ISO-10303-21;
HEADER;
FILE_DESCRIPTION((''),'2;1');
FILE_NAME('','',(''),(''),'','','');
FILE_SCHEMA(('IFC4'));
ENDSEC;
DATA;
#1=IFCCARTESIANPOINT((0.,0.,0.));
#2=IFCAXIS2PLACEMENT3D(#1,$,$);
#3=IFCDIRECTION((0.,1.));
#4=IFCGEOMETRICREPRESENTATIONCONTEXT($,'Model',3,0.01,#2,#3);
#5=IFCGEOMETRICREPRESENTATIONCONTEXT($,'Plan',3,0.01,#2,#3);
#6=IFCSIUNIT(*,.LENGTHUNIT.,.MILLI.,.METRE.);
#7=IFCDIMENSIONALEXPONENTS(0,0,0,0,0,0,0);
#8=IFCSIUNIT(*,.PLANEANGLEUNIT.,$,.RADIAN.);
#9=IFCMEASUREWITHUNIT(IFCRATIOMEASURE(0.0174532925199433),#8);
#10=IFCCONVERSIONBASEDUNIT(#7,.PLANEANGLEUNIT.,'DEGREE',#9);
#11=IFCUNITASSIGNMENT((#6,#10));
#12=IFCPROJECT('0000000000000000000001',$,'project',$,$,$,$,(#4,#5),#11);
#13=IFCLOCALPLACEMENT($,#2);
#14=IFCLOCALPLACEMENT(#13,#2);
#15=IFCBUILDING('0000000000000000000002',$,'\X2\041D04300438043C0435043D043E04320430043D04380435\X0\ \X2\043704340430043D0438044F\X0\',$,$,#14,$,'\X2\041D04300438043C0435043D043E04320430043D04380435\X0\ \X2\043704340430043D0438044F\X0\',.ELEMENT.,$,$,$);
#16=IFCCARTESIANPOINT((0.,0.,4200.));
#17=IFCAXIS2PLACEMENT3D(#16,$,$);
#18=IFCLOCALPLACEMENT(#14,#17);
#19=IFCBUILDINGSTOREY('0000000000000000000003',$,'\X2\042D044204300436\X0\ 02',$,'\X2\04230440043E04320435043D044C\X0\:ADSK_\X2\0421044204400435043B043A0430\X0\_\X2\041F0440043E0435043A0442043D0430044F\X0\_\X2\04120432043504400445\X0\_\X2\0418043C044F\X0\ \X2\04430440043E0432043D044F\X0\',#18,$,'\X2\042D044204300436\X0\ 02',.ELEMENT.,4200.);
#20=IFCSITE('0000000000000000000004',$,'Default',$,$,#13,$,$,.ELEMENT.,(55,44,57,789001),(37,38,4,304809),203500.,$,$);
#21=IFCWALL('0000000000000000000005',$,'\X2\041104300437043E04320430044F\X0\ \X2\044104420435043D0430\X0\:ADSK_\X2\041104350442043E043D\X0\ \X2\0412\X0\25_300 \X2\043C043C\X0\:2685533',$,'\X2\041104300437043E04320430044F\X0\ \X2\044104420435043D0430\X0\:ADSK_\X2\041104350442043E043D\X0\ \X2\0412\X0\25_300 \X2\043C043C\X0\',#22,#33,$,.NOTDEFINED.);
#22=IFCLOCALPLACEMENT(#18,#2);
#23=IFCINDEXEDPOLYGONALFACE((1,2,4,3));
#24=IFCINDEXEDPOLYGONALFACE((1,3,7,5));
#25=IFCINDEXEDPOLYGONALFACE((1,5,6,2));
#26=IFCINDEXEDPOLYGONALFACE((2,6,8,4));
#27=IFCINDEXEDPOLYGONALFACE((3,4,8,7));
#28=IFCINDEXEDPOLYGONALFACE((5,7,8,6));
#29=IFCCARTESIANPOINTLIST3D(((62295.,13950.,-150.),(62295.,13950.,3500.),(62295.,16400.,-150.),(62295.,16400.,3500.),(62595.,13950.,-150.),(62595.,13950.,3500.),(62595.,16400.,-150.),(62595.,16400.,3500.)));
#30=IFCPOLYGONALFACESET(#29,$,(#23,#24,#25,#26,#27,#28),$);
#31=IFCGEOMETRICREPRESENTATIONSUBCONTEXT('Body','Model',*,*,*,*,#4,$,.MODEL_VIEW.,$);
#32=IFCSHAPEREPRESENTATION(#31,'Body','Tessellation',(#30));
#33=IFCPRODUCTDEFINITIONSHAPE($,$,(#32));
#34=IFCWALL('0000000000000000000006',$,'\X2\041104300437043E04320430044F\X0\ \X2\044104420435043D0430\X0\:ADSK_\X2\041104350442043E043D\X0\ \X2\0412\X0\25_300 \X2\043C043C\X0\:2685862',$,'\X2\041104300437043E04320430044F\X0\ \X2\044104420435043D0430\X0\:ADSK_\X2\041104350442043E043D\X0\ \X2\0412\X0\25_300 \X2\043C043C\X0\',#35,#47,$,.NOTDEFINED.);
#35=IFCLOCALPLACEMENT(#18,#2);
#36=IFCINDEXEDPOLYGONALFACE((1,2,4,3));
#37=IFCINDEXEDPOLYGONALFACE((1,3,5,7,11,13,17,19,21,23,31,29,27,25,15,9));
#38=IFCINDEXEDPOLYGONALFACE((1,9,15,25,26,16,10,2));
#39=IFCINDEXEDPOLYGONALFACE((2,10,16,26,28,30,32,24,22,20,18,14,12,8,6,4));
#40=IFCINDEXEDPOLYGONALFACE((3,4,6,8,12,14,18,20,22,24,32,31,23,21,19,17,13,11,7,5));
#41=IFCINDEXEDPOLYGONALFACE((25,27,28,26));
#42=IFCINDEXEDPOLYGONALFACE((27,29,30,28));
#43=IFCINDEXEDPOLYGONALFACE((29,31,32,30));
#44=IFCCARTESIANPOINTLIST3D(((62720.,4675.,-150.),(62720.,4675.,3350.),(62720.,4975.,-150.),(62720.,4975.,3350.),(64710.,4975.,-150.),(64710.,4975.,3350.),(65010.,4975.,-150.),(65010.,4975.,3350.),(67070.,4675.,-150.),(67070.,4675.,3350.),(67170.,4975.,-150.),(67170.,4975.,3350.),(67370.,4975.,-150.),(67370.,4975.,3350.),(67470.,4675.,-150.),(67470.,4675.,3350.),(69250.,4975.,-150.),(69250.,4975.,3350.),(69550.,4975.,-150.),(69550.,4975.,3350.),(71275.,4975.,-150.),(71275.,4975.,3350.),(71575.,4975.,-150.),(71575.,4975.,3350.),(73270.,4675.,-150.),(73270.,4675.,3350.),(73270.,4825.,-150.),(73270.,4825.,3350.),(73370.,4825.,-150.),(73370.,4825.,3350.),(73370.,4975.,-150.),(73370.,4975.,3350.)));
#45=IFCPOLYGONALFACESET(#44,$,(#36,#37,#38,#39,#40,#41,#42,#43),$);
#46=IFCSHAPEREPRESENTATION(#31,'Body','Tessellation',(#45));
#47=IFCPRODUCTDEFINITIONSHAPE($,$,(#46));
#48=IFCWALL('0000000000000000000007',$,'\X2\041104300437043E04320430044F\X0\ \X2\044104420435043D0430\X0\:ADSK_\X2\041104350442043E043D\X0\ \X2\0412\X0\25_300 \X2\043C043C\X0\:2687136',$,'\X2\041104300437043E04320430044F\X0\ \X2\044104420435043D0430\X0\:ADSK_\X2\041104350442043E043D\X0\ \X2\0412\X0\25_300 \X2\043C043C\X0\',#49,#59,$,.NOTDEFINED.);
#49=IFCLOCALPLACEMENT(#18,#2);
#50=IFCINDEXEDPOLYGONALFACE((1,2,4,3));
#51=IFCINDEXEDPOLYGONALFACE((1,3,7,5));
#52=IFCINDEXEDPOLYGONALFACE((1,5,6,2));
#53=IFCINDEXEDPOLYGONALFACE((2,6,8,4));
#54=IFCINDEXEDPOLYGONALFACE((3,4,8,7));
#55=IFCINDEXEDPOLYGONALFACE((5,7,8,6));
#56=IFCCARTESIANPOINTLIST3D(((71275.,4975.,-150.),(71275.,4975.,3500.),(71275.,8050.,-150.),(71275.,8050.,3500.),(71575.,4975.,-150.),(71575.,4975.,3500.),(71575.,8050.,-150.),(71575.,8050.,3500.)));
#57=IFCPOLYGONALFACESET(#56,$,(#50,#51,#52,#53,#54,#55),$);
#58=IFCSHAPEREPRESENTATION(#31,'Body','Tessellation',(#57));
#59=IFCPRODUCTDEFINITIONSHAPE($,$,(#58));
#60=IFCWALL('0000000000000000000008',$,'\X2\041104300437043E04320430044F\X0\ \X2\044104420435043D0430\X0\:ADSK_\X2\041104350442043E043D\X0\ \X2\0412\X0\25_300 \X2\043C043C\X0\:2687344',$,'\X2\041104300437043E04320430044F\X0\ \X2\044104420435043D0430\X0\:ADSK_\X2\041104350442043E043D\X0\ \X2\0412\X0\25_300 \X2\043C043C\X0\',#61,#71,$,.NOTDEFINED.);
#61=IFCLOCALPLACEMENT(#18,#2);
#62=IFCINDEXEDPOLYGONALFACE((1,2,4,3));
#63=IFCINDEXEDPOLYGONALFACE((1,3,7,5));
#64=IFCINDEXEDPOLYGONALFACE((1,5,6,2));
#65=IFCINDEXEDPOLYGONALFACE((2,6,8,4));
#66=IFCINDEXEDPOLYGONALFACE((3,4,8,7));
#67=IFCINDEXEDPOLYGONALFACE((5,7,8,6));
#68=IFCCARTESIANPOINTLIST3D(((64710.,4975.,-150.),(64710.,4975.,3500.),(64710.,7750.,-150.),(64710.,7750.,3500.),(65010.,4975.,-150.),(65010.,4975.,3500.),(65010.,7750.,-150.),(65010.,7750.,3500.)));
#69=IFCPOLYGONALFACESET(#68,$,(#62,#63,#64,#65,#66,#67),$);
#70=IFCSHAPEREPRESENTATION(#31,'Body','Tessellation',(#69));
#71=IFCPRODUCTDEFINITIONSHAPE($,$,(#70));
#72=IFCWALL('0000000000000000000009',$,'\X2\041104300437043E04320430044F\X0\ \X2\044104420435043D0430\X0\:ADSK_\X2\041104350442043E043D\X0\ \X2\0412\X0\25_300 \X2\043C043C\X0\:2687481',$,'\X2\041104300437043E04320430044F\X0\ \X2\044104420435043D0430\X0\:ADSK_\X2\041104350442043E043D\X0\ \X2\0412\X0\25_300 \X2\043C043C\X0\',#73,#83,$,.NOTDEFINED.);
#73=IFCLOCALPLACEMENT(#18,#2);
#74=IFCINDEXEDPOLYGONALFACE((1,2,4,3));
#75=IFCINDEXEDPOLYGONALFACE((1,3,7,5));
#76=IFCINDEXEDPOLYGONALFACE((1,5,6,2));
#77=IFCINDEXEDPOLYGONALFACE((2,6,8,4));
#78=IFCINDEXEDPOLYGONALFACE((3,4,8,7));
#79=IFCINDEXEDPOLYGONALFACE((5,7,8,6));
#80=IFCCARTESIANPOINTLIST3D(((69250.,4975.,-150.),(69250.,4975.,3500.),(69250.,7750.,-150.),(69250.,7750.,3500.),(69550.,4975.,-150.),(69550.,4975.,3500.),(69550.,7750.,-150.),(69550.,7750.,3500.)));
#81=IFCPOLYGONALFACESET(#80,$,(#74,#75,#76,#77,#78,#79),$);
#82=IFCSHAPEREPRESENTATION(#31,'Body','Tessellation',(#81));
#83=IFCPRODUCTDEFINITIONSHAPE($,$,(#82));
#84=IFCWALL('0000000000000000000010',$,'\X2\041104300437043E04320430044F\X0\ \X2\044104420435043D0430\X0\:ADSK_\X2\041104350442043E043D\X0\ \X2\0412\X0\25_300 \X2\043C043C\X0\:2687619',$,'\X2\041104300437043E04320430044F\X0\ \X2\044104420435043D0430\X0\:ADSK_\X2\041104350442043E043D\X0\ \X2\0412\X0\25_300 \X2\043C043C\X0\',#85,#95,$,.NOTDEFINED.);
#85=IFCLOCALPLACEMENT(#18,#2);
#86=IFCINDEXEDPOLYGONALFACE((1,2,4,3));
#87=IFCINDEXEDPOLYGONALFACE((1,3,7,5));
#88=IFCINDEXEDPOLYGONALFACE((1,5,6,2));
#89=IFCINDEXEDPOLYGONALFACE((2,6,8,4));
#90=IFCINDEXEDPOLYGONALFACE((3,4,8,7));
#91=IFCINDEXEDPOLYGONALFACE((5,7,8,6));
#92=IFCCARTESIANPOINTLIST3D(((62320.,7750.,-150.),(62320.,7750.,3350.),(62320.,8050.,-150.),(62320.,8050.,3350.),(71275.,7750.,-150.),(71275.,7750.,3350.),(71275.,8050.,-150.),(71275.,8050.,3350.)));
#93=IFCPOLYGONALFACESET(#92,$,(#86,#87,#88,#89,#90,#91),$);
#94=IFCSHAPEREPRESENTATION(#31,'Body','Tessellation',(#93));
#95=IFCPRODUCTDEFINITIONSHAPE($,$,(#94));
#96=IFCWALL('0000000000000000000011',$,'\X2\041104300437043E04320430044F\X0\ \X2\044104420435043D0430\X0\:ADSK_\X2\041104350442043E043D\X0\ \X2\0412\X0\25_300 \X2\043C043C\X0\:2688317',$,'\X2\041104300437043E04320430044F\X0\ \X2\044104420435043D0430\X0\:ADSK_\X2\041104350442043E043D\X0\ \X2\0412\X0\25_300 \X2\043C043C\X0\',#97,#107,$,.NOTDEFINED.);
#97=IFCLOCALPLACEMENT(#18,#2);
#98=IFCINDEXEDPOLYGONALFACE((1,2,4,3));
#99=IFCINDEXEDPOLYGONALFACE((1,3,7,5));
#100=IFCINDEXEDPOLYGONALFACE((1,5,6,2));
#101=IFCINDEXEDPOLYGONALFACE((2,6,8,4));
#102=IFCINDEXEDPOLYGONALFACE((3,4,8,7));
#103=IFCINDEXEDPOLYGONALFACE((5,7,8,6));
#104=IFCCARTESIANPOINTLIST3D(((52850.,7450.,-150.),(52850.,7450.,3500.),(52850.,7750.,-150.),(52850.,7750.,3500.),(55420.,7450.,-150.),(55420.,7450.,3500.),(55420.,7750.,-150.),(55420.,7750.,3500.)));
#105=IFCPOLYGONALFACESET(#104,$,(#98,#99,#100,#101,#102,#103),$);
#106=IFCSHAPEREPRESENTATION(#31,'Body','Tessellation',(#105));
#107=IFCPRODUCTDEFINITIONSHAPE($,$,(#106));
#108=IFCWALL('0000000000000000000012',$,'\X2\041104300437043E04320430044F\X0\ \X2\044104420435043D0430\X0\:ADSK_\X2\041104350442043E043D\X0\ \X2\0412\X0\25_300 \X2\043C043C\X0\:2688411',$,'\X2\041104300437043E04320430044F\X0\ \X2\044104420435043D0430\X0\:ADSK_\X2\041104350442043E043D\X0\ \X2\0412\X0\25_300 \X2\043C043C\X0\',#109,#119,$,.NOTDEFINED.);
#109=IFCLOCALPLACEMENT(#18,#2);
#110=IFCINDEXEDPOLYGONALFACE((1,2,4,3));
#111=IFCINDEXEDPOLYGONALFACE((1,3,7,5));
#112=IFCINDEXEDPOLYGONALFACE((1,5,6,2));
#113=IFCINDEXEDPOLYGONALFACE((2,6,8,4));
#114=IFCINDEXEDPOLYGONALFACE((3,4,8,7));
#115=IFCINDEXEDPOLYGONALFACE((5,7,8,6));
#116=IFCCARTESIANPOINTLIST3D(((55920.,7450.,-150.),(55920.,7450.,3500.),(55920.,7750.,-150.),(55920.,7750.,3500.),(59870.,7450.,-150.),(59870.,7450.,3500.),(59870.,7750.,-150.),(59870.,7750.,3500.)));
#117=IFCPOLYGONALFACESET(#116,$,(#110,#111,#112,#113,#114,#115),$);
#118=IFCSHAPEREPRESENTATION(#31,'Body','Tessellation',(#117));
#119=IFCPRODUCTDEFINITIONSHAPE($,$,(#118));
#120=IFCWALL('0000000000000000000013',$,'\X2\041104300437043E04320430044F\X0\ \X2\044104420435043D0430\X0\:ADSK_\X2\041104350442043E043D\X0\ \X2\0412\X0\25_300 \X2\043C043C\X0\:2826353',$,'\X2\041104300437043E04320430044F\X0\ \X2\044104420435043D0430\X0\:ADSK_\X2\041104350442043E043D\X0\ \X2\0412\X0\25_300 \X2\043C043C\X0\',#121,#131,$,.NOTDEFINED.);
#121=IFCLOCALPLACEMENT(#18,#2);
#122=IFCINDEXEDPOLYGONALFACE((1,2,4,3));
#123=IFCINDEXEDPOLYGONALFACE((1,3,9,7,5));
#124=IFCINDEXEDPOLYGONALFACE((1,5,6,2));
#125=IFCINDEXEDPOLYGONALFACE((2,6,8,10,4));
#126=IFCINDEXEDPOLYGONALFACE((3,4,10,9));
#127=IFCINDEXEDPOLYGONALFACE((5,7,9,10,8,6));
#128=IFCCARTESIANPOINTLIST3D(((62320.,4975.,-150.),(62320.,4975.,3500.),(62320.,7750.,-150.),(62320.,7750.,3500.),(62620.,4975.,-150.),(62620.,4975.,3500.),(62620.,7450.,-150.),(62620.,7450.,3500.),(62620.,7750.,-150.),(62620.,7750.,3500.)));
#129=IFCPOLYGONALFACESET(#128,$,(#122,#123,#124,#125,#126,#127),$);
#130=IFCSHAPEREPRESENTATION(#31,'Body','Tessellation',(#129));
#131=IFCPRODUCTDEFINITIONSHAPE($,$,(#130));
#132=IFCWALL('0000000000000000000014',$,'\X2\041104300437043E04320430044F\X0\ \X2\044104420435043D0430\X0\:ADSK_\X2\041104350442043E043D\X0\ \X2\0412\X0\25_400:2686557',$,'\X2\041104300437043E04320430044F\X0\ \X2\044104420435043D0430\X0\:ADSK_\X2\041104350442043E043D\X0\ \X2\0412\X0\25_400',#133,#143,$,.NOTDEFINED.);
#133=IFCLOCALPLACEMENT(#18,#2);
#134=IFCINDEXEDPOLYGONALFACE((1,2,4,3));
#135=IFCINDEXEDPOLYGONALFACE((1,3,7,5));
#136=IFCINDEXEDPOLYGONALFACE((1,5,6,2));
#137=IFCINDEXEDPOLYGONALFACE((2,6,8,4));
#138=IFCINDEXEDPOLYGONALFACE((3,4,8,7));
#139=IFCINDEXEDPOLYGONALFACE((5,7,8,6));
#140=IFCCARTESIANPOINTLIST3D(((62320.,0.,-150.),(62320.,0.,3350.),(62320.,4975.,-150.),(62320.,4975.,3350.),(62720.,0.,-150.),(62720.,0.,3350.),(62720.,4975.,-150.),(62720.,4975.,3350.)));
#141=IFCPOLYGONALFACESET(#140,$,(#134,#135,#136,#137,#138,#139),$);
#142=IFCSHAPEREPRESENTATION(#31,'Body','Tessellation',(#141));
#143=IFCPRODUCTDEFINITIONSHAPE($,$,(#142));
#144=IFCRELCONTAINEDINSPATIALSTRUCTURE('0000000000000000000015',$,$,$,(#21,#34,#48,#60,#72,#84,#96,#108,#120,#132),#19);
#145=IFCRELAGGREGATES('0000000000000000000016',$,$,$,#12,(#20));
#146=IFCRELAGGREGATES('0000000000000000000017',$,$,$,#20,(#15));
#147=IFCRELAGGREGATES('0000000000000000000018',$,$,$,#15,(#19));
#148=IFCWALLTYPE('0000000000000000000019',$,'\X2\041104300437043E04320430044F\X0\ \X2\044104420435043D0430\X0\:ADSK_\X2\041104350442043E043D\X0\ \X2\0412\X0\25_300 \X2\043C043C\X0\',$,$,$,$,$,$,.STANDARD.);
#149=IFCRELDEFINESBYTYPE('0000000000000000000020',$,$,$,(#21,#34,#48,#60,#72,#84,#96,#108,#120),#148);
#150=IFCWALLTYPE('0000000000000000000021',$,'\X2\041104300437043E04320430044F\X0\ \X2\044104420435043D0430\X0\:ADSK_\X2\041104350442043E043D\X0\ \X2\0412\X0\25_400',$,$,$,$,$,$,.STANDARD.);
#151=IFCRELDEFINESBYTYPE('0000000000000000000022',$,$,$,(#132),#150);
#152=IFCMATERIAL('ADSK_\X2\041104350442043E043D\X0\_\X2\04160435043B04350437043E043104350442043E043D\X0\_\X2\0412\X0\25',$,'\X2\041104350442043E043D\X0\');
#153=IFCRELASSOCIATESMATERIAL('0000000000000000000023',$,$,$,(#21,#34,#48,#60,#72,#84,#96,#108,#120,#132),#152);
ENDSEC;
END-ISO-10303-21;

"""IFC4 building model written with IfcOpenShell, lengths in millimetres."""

from ifc_helpers import new_model, entity, si_unit, converted_unit, direction, frame, origin, place, context, subcontext, project, spatial, indexed_curve, outline, extrude, material, type_object, element, save


model = new_model("IFC4")

# Units and contexts
model_context = context("Model", 3, precision=0.01, world=origin(), true_north=direction((0.0, 1.0)))
plan_context = context("Plan", 3, precision=0.01, world=origin(), true_north=direction((0.0, 1.0)))
body_context = subcontext(model_context, "Body", "Model", "MODEL_VIEW")
ifc_project = project(units=[si_unit("LENGTHUNIT", "METRE", prefix="MILLI"), converted_unit("PLANEANGLEUNIT", "DEGREE", entity("IfcRatioMeasure", 0.0174532925199433), si_unit("PLANEANGLEUNIT", "RADIAN"), dimensions=[0, 0, 0, 0, 0, 0, 0])], contexts=[model_context, plan_context])

# Site, building, storey
site_placement = place(None, origin())
site = spatial("IfcSite", under=ifc_project, at=site_placement, Name="Default", CompositionType="ELEMENT", RefLatitude=(55, 44, 57, 789001), RefLongitude=(37, 38, 4, 304809), RefElevation=203500.0)
building_placement = place(site_placement, origin())
building = spatial("IfcBuilding", under=site, at=building_placement, Name="Наименование здания", LongName="Наименование здания", CompositionType="ELEMENT")
storey_placement = place(building_placement, frame((0.0, 0.0, 4200.0)))
storey = spatial("IfcBuildingStorey", under=building, at=storey_placement, Name="Этаж 02", ObjectType="Уровень:ADSK_Стрелка_Проектная_Вверх_Имя уровня", LongName="Этаж 02", CompositionType="ELEMENT", Elevation=4200.0)

# Walls
ifc_material = material(Name="ADSK_Бетон_Железобетон_В25", Category="Бетон")
wall_type_1 = type_object("IfcWallType", Name="Базовая стена:ADSK_Бетон В25_300 мм", PredefinedType="STANDARD")
wall_1_placement = place(storey_placement, frame((62445.0, 13950.0, -150.0), z_axis=(0.0, 0.0, 1.0), x_axis=(0.0, 1.0, 0.0)))
element("IfcWall", 1, at=wall_1_placement, inside=storey, type_object=wall_type_1, material=ifc_material, Name="Базовая стена:ADSK_Бетон В25_300 мм:2685533", ObjectType="Базовая стена:ADSK_Бетон В25_300 мм", PredefinedType="NOTDEFINED", context=body_context, shape_type="SweptSolid", body=[
    extrude(outline(indexed_curve([(2450.0, 150.0), (0.0, 150.0), (0.0, -150.0), (2450.0, -150.0), (2450.0, 150.0)], self_intersect=False)), origin(), (0.0, 0.0, 1.0), 3650.0),
])
wall_2_placement = place(storey_placement, frame((62720.0, 4825.0, -150.0)))
element("IfcWall", 2, at=wall_2_placement, inside=storey, type_object=wall_type_1, material=ifc_material, Name="Базовая стена:ADSK_Бетон В25_300 мм:2685862", ObjectType="Базовая стена:ADSK_Бетон В25_300 мм", PredefinedType="NOTDEFINED", context=body_context, shape_type="SweptSolid", body=[
    extrude(outline(indexed_curve([(10550.0, -150.0), (10550.0, 0.0), (10650.0, 0.0), (10650.0, 150.0), (8855.0, 150.0), (8555.0, 150.0), (6830.0, 150.0), (6530.0, 150.0), (4650.0, 150.0), (4450.0, 150.0), (2290.0, 150.0), (1990.0, 150.0), (0.0, 150.0), (0.0, -150.0), (4350.0, -150.0), (4750.0, -150.0), (10550.0, -150.0)], self_intersect=False)), origin(), (0.0, 0.0, 1.0), 3500.0),
])
wall_3_placement = place(storey_placement, frame((71425.0, 4975.0, -150.0), z_axis=(0.0, 0.0, 1.0), x_axis=(0.0, 1.0, 0.0)))
element("IfcWall", 3, at=wall_3_placement, inside=storey, type_object=wall_type_1, material=ifc_material, Name="Базовая стена:ADSK_Бетон В25_300 мм:2687136", ObjectType="Базовая стена:ADSK_Бетон В25_300 мм", PredefinedType="NOTDEFINED", context=body_context, shape_type="SweptSolid", body=[
    extrude(outline(indexed_curve([(3075.0, 150.0), (0.0, 150.0), (0.0, -150.0), (3075.0, -150.0), (3075.0, 150.0)], self_intersect=False)), origin(), (0.0, 0.0, 1.0), 3650.0),
])
for number, where, z_axis, x_axis, name in (
    (4, (64860.0, 4975.0, -150.0), (0.0, 0.0, 1.0), (0.0, 1.0, 0.0), "Базовая стена:ADSK_Бетон В25_300 мм:2687344"),
    (5, (69400.0, 4975.0, -150.0), (0.0, 0.0, 1.0), (0.0, 1.0, 0.0), "Базовая стена:ADSK_Бетон В25_300 мм:2687481"),
):
    element("IfcWall", number, at=place(storey_placement, frame(where, z_axis=z_axis, x_axis=x_axis)), inside=storey, type_object=wall_type_1, material=ifc_material, Name=name, ObjectType="Базовая стена:ADSK_Бетон В25_300 мм", PredefinedType="NOTDEFINED", context=body_context, shape_type="SweptSolid", body=[
        extrude(outline(indexed_curve([(2775.0, 150.0), (0.0, 150.0), (0.0, -150.0), (2775.0, -150.0), (2775.0, 150.0)], self_intersect=False)), origin(), (0.0, 0.0, 1.0), 3650.0),
    ])
wall_4_placement = place(storey_placement, frame((62320.0, 7900.0, -150.0)))
element("IfcWall", 6, at=wall_4_placement, inside=storey, type_object=wall_type_1, material=ifc_material, Name="Базовая стена:ADSK_Бетон В25_300 мм:2687619", ObjectType="Базовая стена:ADSK_Бетон В25_300 мм", PredefinedType="NOTDEFINED", context=body_context, shape_type="SweptSolid", body=[
    extrude(outline(indexed_curve([(8955.0, 150.0), (0.0, 150.0), (0.0, -150.0), (8955.0, -150.0), (8955.0, 150.0)], self_intersect=False)), origin(), (0.0, 0.0, 1.0), 3500.0),
])
wall_5_placement = place(storey_placement, frame((55420.0, 7600.0, -150.0), z_axis=(0.0, 0.0, 1.0), x_axis=(-1.0, 0.0, 0.0)))
element("IfcWall", 7, at=wall_5_placement, inside=storey, type_object=wall_type_1, material=ifc_material, Name="Базовая стена:ADSK_Бетон В25_300 мм:2688317", ObjectType="Базовая стена:ADSK_Бетон В25_300 мм", PredefinedType="NOTDEFINED", context=body_context, shape_type="SweptSolid", body=[
    extrude(outline(indexed_curve([(2570.0, 150.0), (0.0, 150.0), (0.0, -150.0), (2570.0, -150.0), (2570.0, 150.0)], self_intersect=False)), origin(), (0.0, 0.0, 1.0), 3650.0),
])
wall_6_placement = place(storey_placement, frame((55920.0, 7600.0, -150.0)))
element("IfcWall", 8, at=wall_6_placement, inside=storey, type_object=wall_type_1, material=ifc_material, Name="Базовая стена:ADSK_Бетон В25_300 мм:2688411", ObjectType="Базовая стена:ADSK_Бетон В25_300 мм", PredefinedType="NOTDEFINED", context=body_context, shape_type="SweptSolid", body=[
    extrude(outline(indexed_curve([(3950.0, 150.0), (0.0, 150.0), (0.0, -150.0), (3950.0, -150.0), (3950.0, 150.0)], self_intersect=False)), origin(), (0.0, 0.0, 1.0), 3650.0),
])
wall_7_placement = place(storey_placement, frame((62470.0, 4675.0, -150.0), z_axis=(0.0, 0.0, 1.0), x_axis=(0.0, 1.0, 0.0)))
element("IfcWall", 9, at=wall_7_placement, inside=storey, type_object=wall_type_1, material=ifc_material, Name="Базовая стена:ADSK_Бетон В25_300 мм:2826353", ObjectType="Базовая стена:ADSK_Бетон В25_300 мм", PredefinedType="NOTDEFINED", context=body_context, shape_type="SweptSolid", body=[
    extrude(outline(indexed_curve([(3075.0, -150.0), (3075.0, 150.0), (300.0, 150.0), (300.0, -150.0), (2775.0, -150.0), (3075.0, -150.0)], self_intersect=False)), origin(), (0.0, 0.0, 1.0), 3650.0),
])
wall_type_2 = type_object("IfcWallType", Name="Базовая стена:ADSK_Бетон В25_400", PredefinedType="STANDARD")
wall_8_placement = place(storey_placement, frame((62520.0, 0.0, -150.0), z_axis=(0.0, 0.0, 1.0), x_axis=(0.0, 1.0, 0.0)))
element("IfcWall", 10, at=wall_8_placement, inside=storey, type_object=wall_type_2, material=ifc_material, Name="Базовая стена:ADSK_Бетон В25_400:2686557", ObjectType="Базовая стена:ADSK_Бетон В25_400", PredefinedType="NOTDEFINED", context=body_context, shape_type="SweptSolid", body=[
    extrude(outline(indexed_curve([(4975.0, 200.0), (0.0, 200.0), (0.0, -200.0), (4975.0, -200.0), (4975.0, 200.0)], self_intersect=False)), origin(), (0.0, 0.0, 1.0), 3500.0),
])

save(model, "model.ifc")
